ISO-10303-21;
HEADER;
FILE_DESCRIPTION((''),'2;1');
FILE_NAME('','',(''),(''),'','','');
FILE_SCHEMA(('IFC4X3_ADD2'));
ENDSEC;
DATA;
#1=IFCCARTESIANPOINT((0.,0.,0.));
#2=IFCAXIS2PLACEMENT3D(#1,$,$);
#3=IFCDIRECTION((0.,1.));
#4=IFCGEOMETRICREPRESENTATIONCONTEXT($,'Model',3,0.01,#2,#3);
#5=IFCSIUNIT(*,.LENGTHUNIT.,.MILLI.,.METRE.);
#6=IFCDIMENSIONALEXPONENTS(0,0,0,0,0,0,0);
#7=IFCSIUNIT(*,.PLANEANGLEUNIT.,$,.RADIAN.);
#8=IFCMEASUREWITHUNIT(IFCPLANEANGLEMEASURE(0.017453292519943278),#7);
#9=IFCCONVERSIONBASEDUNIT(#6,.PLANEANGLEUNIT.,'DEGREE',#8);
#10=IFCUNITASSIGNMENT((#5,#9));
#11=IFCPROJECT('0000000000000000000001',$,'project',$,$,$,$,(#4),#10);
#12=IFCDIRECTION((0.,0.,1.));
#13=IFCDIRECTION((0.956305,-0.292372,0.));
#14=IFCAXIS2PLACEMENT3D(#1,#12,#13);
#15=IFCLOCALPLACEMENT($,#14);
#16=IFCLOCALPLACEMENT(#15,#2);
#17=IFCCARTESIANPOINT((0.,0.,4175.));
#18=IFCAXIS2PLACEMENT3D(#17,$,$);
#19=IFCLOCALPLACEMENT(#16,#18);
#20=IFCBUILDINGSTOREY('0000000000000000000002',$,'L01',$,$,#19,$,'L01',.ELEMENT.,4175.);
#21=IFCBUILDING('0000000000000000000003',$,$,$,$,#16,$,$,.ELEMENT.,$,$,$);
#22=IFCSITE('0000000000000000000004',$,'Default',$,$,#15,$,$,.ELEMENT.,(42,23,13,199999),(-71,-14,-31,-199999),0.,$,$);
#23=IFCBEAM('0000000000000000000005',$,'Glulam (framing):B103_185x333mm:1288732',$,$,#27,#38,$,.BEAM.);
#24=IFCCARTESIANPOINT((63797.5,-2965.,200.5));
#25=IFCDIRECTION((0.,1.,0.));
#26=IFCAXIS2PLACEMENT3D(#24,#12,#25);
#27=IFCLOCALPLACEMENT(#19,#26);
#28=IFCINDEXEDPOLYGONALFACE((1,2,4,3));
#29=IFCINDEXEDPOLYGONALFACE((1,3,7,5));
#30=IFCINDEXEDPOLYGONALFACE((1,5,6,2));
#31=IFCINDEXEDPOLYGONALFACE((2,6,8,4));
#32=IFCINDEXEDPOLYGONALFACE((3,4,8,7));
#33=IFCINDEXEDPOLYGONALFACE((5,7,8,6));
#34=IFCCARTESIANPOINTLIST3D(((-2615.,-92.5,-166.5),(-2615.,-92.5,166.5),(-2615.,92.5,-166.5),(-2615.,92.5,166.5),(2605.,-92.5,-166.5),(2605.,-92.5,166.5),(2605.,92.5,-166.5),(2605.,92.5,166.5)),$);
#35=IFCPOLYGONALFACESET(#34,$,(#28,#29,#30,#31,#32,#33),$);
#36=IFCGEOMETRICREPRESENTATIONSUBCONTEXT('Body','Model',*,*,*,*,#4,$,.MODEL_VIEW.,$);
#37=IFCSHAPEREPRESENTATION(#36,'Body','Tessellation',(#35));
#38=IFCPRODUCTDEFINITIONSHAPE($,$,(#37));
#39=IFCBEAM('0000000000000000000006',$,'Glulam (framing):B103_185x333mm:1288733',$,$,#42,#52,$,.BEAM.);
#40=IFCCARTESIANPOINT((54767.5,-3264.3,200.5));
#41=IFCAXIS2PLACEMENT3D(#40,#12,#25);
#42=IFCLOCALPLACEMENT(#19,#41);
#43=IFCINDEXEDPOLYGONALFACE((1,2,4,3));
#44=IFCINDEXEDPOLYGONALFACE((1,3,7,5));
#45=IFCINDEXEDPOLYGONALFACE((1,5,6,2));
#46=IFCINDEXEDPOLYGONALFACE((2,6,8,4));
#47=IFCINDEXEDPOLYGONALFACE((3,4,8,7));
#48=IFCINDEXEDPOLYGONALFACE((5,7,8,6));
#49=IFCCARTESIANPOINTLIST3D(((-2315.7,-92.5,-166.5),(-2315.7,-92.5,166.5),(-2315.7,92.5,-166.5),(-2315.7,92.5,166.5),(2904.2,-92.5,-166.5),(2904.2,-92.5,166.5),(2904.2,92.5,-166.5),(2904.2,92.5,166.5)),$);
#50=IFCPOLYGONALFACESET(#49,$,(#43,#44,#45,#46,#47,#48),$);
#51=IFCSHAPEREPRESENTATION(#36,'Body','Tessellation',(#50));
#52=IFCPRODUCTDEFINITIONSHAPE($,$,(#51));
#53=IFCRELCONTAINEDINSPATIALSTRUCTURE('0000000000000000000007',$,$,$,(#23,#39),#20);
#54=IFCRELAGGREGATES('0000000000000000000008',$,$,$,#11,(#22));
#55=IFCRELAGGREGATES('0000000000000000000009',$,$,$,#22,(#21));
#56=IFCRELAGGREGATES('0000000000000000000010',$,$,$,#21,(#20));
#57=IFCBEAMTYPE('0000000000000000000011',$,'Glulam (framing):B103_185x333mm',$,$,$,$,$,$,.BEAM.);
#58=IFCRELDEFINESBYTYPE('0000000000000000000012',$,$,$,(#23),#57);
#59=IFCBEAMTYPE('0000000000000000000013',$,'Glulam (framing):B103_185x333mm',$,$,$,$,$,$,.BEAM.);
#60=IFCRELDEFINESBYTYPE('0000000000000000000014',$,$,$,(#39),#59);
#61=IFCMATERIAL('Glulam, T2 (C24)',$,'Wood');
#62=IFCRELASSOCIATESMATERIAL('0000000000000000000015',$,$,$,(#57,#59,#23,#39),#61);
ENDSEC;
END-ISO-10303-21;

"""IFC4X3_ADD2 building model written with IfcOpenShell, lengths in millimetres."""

from ifc_helpers import new_model, entity, si_unit, converted_unit, direction, frame, origin, origin_2d_with_axis, place, context, subcontext, project, spatial, rectangle, extrude, source, transform, mapped, material, material_profile, profile_set, profile_usage, type_object, type_shapes, element, save


model = new_model("IFC4X3_ADD2")

# Units and contexts
model_context = context("Model", 3, precision=0.01, world=origin(), true_north=direction((0.0, 1.0)))
body_context = subcontext(model_context, "Body", "Model", "MODEL_VIEW")
ifc_project = project(units=[si_unit("LENGTHUNIT", "METRE", prefix="MILLI"), converted_unit("PLANEANGLEUNIT", "DEGREE", entity("IfcPlaneAngleMeasure", 0.017453292519943278), si_unit("PLANEANGLEUNIT", "RADIAN"), dimensions=[0, 0, 0, 0, 0, 0, 0])], contexts=[model_context])

# Site, building, storey
site_placement = place(None, frame((0.0, 0.0, 0.0), z_axis=(0.0, 0.0, 1.0), x_axis=(0.956305, -0.292372, 0.0)))
site = spatial("IfcSite", under=ifc_project, at=site_placement, Name="Default", CompositionType="ELEMENT", RefLatitude=(42, 23, 13, 199999), RefLongitude=(-71, -14, -31, -199999), RefElevation=0.0)
building_placement = place(site_placement, origin())
building = spatial("IfcBuilding", under=site, at=building_placement, CompositionType="ELEMENT")
storey_placement = place(building_placement, frame((0.0, 0.0, 4175.0)))
storey = spatial("IfcBuildingStorey", under=building, at=storey_placement, Name="L01", LongName="L01", CompositionType="ELEMENT", Elevation=4175.0)

# Beams
ifc_material_1 = material(Name="Glulam, T2 (C24)", Category="Wood")
ifc_material_profile_1 = material_profile(ifc_material_1, rectangle(XDim=3200.0, YDim=185.0, at=origin_2d_with_axis()), Name="B103_185x333mm")
ifc_profile_set_1 = profile_set([ifc_material_profile_1], Name="B103_185x333mm")
ifc_profile_usage_1 = profile_usage(ifc_profile_set_1, cardinal=8)
beam_type_1 = type_object("IfcBeamType", Name="Glulam (framing):B103_185x333mm", PredefinedType="BEAM", material=ifc_profile_set_1)
shared_shape_1 = source(origin(), body_context, "Body", "SweptSolid", [
    extrude(rectangle(XDim=5220.0, YDim=185.0, at=origin_2d_with_axis()), frame((-5.0, 0.0, -166.5), z_axis=(0.0, 0.0, 1.0), x_axis=(-1.0, 0.0, 0.0)), (0.0, 0.0, 1.0), 333.0),
])
type_shapes(beam_type_1, [shared_shape_1])
beam_1_placement = place(storey_placement, frame((63797.5, -2965.0, 200.5), z_axis=(0.0, 0.0, 1.0), x_axis=(0.0, 1.0, 0.0)))
element("IfcBeam", 1, at=beam_1_placement, inside=storey, type_object=beam_type_1, material=ifc_profile_usage_1, Name="Glulam (framing):B103_185x333mm:1288732", PredefinedType="BEAM", context=body_context, shape_type="MappedRepresentation", body=[
    mapped(shared_shape_1, transform((0.0, 0.0, 0.0), scale=1.0)),
])
beam_type_2 = type_object("IfcBeamType", Name="Glulam (framing):B103_185x333mm", PredefinedType="BEAM", material=ifc_profile_set_1)
shared_shape_2 = source(origin(), body_context, "Body", "SweptSolid", [
    extrude(rectangle(XDim=185.0, YDim=5220.0, at=origin_2d_with_axis()), frame((294.3, 0.0, -166.5), z_axis=(0.0, 0.0, 1.0), x_axis=(0.0, 1.0, 0.0)), (0.0, 0.0, 1.0), 333.0),
])
type_shapes(beam_type_2, [shared_shape_2])
beam_2_placement = place(storey_placement, frame((54767.5, -3264.3, 200.5), z_axis=(0.0, 0.0, 1.0), x_axis=(0.0, 1.0, 0.0)))
element("IfcBeam", 2, at=beam_2_placement, inside=storey, type_object=beam_type_2, material=ifc_profile_usage_1, Name="Glulam (framing):B103_185x333mm:1288733", PredefinedType="BEAM", context=body_context, shape_type="MappedRepresentation", body=[
    mapped(shared_shape_2, transform((0.0, 0.0, 0.0), scale=1.0)),
])

save(model, "model.ifc")
